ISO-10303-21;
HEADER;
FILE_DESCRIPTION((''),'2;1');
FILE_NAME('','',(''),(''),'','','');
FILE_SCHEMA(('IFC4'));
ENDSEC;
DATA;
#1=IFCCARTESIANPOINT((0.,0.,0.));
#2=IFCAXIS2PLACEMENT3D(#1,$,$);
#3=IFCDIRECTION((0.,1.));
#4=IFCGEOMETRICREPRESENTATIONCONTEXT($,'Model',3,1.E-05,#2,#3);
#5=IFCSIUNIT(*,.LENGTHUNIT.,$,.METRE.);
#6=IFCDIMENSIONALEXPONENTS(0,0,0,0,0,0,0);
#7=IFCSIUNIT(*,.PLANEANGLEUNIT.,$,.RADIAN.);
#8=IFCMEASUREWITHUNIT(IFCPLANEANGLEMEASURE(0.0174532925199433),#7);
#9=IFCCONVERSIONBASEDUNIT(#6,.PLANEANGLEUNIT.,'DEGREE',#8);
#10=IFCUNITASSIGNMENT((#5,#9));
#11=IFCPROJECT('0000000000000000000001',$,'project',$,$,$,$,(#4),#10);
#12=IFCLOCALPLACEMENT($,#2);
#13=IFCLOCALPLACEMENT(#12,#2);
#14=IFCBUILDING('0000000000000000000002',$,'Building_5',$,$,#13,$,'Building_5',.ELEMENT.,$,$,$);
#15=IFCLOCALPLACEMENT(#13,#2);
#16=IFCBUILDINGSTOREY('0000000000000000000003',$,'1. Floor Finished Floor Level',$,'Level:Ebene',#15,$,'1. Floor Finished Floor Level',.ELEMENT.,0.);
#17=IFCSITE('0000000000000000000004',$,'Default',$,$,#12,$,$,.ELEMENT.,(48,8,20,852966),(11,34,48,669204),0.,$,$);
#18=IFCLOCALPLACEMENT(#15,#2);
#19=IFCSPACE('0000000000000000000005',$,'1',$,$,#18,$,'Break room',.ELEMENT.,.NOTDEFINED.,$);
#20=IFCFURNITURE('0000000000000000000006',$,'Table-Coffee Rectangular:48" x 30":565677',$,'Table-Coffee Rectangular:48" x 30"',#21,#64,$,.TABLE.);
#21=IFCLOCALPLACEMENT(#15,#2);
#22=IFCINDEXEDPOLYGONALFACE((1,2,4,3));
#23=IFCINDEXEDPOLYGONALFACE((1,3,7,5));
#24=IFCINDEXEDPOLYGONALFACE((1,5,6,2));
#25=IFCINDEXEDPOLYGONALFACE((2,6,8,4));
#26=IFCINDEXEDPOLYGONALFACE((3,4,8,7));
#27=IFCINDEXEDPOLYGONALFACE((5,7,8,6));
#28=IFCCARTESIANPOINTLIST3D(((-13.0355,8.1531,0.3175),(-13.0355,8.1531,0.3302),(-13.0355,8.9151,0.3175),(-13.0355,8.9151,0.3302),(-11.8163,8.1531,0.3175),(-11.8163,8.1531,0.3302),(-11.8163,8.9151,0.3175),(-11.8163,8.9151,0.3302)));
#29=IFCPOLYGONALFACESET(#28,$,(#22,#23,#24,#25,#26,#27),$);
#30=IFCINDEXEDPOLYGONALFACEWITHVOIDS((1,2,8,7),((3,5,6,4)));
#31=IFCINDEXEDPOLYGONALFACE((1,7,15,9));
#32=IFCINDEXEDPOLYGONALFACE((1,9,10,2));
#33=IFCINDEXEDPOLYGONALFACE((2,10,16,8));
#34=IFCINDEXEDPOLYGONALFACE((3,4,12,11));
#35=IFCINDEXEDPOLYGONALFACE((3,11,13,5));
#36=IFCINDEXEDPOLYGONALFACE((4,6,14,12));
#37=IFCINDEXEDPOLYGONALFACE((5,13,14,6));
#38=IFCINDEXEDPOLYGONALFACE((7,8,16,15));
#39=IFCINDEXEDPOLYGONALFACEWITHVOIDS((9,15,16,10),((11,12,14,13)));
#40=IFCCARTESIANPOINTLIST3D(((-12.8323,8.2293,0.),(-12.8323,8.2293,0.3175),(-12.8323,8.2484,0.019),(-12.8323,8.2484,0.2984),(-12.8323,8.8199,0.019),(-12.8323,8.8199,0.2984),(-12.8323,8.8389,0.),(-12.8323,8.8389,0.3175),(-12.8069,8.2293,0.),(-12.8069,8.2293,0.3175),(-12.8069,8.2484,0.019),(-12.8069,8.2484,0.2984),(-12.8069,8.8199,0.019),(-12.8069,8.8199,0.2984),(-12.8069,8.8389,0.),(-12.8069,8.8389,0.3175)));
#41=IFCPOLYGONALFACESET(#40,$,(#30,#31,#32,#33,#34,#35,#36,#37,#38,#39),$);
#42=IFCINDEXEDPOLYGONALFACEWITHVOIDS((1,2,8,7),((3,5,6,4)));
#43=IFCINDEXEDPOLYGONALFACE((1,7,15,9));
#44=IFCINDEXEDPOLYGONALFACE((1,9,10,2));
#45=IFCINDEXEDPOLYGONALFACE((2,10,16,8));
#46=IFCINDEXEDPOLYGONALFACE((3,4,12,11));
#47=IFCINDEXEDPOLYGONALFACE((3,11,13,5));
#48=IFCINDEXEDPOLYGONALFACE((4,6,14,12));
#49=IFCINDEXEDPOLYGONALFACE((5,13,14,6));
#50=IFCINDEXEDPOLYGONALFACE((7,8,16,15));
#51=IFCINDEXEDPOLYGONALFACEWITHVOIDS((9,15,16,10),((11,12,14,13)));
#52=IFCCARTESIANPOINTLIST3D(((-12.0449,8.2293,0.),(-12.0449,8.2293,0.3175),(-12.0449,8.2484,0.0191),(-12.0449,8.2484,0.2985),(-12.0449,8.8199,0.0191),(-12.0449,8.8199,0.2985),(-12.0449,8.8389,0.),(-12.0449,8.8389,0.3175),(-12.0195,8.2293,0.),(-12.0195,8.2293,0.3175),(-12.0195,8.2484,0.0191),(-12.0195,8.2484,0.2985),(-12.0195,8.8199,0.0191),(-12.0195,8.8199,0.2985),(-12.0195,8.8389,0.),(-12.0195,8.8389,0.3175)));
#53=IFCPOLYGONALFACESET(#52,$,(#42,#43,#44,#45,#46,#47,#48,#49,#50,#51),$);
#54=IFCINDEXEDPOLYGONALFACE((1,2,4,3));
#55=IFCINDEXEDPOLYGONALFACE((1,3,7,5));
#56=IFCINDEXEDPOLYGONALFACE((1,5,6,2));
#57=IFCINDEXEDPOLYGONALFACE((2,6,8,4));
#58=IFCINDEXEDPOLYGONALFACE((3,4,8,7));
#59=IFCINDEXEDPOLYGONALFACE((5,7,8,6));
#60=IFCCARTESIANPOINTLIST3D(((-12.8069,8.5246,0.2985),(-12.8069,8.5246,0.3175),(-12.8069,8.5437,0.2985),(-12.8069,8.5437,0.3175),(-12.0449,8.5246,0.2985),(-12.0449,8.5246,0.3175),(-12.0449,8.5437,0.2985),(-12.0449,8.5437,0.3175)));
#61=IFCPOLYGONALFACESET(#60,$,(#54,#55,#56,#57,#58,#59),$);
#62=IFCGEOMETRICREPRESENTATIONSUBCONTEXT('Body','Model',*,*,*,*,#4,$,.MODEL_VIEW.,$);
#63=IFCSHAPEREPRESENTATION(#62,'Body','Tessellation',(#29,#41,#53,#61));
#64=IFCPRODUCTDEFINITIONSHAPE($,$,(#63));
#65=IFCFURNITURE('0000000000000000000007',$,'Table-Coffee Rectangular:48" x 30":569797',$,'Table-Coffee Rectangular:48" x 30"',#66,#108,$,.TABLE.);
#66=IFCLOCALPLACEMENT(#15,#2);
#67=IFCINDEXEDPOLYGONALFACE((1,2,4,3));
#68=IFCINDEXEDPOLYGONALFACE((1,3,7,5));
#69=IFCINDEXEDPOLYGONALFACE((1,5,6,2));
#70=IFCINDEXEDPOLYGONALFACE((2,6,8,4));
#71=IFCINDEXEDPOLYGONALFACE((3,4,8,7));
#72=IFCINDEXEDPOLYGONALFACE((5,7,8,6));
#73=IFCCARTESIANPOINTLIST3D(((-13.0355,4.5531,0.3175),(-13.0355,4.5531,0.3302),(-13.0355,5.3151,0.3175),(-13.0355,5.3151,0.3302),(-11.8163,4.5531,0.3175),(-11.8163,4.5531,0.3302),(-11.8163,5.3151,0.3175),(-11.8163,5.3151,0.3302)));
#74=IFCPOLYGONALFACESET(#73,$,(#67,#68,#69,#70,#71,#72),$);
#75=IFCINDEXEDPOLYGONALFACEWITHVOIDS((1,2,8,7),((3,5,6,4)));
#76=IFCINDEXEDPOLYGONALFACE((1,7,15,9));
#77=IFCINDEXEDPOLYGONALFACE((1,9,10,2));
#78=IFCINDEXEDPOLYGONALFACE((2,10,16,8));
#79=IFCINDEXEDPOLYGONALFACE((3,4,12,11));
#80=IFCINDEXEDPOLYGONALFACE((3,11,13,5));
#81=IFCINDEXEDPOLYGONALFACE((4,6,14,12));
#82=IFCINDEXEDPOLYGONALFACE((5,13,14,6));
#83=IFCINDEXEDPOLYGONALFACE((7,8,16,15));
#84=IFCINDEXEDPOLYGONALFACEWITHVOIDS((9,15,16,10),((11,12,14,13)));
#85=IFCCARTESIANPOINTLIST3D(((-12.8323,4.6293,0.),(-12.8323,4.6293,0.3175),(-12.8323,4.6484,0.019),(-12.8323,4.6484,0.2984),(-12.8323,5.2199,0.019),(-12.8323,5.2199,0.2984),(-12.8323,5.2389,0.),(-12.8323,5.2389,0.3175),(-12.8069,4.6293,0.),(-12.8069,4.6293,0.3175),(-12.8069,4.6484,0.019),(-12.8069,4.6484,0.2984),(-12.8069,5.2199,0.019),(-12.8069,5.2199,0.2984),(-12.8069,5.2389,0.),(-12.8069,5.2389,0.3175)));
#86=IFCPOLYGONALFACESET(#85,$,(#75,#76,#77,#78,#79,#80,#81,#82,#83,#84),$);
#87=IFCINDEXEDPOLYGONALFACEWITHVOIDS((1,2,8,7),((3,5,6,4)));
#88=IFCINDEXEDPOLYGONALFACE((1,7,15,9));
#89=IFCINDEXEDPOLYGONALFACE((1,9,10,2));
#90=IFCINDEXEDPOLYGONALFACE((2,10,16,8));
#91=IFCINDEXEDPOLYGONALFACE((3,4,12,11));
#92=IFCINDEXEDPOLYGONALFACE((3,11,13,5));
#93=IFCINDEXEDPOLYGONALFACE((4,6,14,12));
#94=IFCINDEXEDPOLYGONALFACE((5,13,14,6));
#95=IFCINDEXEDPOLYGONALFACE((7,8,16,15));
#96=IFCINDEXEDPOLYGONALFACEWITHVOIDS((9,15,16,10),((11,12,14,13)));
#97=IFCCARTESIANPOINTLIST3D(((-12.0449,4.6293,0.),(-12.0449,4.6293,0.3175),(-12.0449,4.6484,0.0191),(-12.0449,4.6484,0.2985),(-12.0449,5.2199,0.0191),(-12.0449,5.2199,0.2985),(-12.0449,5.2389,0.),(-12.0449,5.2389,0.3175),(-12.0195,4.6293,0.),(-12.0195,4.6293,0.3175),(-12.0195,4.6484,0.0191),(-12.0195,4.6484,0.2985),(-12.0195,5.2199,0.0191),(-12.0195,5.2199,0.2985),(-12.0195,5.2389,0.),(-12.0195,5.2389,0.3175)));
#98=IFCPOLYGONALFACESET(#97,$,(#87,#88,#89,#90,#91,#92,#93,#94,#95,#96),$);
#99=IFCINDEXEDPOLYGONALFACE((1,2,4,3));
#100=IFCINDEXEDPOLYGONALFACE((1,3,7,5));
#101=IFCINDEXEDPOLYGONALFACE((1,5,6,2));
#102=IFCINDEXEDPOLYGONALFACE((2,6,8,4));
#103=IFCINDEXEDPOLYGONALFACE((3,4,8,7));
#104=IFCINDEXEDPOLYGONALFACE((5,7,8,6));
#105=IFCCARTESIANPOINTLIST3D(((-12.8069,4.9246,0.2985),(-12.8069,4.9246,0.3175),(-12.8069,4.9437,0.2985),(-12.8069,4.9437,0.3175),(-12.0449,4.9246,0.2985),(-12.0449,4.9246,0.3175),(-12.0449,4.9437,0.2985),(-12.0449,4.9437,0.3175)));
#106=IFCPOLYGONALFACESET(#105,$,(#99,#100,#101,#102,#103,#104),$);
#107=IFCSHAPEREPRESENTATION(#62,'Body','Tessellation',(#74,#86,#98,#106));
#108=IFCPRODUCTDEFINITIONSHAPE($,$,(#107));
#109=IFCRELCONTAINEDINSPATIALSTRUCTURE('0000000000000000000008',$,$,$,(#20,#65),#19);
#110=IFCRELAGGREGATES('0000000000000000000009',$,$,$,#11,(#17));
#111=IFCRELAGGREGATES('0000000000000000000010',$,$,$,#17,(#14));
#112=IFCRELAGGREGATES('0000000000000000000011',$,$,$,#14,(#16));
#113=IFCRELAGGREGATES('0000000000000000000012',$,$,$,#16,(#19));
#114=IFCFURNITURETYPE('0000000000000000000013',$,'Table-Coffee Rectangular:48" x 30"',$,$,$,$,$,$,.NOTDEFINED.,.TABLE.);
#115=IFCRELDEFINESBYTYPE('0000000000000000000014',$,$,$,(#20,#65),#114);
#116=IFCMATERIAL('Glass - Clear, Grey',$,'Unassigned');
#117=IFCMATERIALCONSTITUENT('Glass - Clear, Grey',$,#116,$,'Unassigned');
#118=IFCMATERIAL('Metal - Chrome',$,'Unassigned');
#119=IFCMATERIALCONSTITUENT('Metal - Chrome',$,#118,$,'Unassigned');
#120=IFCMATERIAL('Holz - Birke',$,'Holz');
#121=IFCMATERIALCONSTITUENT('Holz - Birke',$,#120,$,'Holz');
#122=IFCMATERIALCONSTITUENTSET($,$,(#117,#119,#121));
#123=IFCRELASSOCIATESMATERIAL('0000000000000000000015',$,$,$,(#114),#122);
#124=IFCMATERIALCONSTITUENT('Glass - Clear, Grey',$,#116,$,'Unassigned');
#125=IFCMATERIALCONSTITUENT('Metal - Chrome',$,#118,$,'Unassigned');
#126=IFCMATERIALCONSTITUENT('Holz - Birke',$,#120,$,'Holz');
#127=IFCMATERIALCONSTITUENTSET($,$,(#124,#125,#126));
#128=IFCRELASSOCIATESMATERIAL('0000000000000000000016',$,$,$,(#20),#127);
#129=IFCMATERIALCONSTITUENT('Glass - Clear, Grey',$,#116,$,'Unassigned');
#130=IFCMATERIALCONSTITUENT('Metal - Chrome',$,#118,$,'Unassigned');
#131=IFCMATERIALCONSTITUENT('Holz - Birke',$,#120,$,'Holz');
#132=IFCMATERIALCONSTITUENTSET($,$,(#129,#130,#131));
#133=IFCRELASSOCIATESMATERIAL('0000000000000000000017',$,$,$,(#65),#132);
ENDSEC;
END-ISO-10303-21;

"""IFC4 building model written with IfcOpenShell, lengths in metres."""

from ifc_helpers import new_model, entity, si_unit, converted_unit, direction, frame, origin, place, context, subcontext, project, spatial, indexed_curve, outline, extrude, source, transform, mapped, material, constituent, constituent_set, type_object, type_shapes, element, save


model = new_model("IFC4")

# Units and contexts
model_context = context("Model", 3, precision=1e-05, world=origin(), true_north=direction((0.0, 1.0)))
body_context = subcontext(model_context, "Body", "Model", "MODEL_VIEW")
ifc_project = project(units=[si_unit("LENGTHUNIT", "METRE"), converted_unit("PLANEANGLEUNIT", "DEGREE", entity("IfcPlaneAngleMeasure", 0.0174532925199433), si_unit("PLANEANGLEUNIT", "RADIAN"), dimensions=[0, 0, 0, 0, 0, 0, 0])], contexts=[model_context])

# Site, building, storey
site_placement = place(None, origin())
site = spatial("IfcSite", under=ifc_project, at=site_placement, Name="Default", CompositionType="ELEMENT", RefLatitude=(48, 8, 20, 852966), RefLongitude=(11, 34, 48, 669204), RefElevation=0.0)
building_placement = place(site_placement, origin())
building = spatial("IfcBuilding", under=site, at=building_placement, Name="Building_5", LongName="Building_5", CompositionType="ELEMENT")
storey_placement = place(building_placement, origin())
storey = spatial("IfcBuildingStorey", under=building, at=storey_placement, Name="1. Floor Finished Floor Level", ObjectType="Level:Ebene", LongName="1. Floor Finished Floor Level", CompositionType="ELEMENT", Elevation=0.0)

# Shared definitions
space_placement = place(storey_placement, origin())
space = spatial("IfcSpace", under=storey, at=space_placement, Name="1", LongName="Break room", CompositionType="ELEMENT", PredefinedType="NOTDEFINED")

# Furniture
ifc_material_1 = material(Name="Glass - Clear, Grey", Category="Unassigned")
ifc_constituent_1 = constituent(ifc_material_1, Name="Glass - Clear, Grey", Category="Unassigned")
ifc_material_2 = material(Name="Metal - Chrome", Category="Unassigned")
ifc_constituent_2 = constituent(ifc_material_2, Name="Metal - Chrome", Category="Unassigned")
ifc_material_3 = material(Name="Holz - Birke", Category="Holz")
ifc_constituent_3 = constituent(ifc_material_3, Name="Holz - Birke", Category="Holz")
ifc_constituent_set_1 = constituent_set(constituents=[ifc_constituent_1, ifc_constituent_2, ifc_constituent_3])
ifc_constituent_4 = constituent(ifc_material_1, Name="Glass - Clear, Grey", Category="Unassigned")
ifc_constituent_5 = constituent(ifc_material_2, Name="Metal - Chrome", Category="Unassigned")
ifc_constituent_6 = constituent(ifc_material_3, Name="Holz - Birke", Category="Holz")
ifc_constituent_set_2 = constituent_set(constituents=[ifc_constituent_4, ifc_constituent_5, ifc_constituent_6])
furniture_type = type_object("IfcFurnitureType", Name="Table-Coffee Rectangular:48\" x 30\"", AssemblyPlace="NOTDEFINED", PredefinedType="TABLE", material=ifc_constituent_set_2)
shared_shape_1 = source(origin(), body_context, "Body", "SweptSolid", [
    extrude(outline(indexed_curve([(-0.6096, -0.381), (0.6096, -0.381), (0.6096, 0.381), (-0.6096, 0.381), (-0.6096, -0.381)], self_intersect=False)), frame((0.6133, 0.3696, 0.3175), z_axis=(0.0, 0.0, 1.0), x_axis=(-1.0, 0.0, 0.0)), (0.0, 0.0, 1.0), 0.0127),
    extrude(outline(indexed_curve([(-0.1588, -0.3048), (0.1588, -0.3048), (0.1588, 0.3048), (-0.1588, 0.3048), (-0.1588, -0.3048)], self_intersect=False), holes=[indexed_curve([(-0.1397, -0.2858), (-0.1397, 0.2858), (0.1397, 0.2858), (0.1397, -0.2858), (-0.1397, -0.2858)], self_intersect=False)]), frame((0.2069, 0.3696, 0.1588), z_axis=(1.0, 0.0, 0.0), x_axis=(0.0, 0.0, -1.0)), (0.0, 0.0, 1.0), 0.0254),
    extrude(outline(indexed_curve([(-0.1587, -0.3048), (0.1587, -0.3048), (0.1587, 0.3048), (-0.1587, 0.3048), (-0.1587, -0.3048)], self_intersect=False), holes=[indexed_curve([(-0.1397, -0.2858), (-0.1397, 0.2858), (0.1397, 0.2858), (0.1397, -0.2858), (-0.1397, -0.2858)], self_intersect=False)]), frame((0.9943, 0.3696, 0.1587), z_axis=(1.0, 0.0, 0.0), x_axis=(0.0, 0.0, -1.0)), (0.0, 0.0, 1.0), 0.0254),
    extrude(outline(indexed_curve([(-0.381, -0.0095), (0.381, -0.0095), (0.381, 0.0095), (-0.381, 0.0095), (-0.381, -0.0095)], self_intersect=False)), frame((0.6133, 0.3696, 0.2985), z_axis=(0.0, 0.0, 1.0), x_axis=(-1.0, 0.0, 0.0)), (0.0, 0.0, 1.0), 0.0191),
])
type_shapes(furniture_type, [shared_shape_1])
furniture_1_placement = place(space_placement, frame((-13.0392, 8.1645, 0.0)))
element("IfcFurniture", 1, at=furniture_1_placement, inside=space, type_object=furniture_type, material=ifc_constituent_set_1, Name="Table-Coffee Rectangular:48\" x 30\":565677", ObjectType="Table-Coffee Rectangular:48\" x 30\"", PredefinedType="TABLE", context=body_context, shape_type="MappedRepresentation", body=[
    mapped(shared_shape_1, transform((0.0, 0.0, 0.0), scale=1.0)),
])
ifc_constituent_7 = constituent(ifc_material_1, Name="Glass - Clear, Grey", Category="Unassigned")
ifc_constituent_8 = constituent(ifc_material_2, Name="Metal - Chrome", Category="Unassigned")
ifc_constituent_9 = constituent(ifc_material_3, Name="Holz - Birke", Category="Holz")
ifc_constituent_set_3 = constituent_set(constituents=[ifc_constituent_7, ifc_constituent_8, ifc_constituent_9])
furniture_2_placement = place(space_placement, frame((-13.0392, 4.5645, 0.0)))
element("IfcFurniture", 2, at=furniture_2_placement, inside=space, type_object=furniture_type, material=ifc_constituent_set_3, Name="Table-Coffee Rectangular:48\" x 30\":569797", ObjectType="Table-Coffee Rectangular:48\" x 30\"", PredefinedType="TABLE", context=body_context, shape_type="MappedRepresentation", body=[
    mapped(shared_shape_1, transform((0.0, 0.0, 0.0), scale=1.0)),
])

save(model, "model.ifc")
